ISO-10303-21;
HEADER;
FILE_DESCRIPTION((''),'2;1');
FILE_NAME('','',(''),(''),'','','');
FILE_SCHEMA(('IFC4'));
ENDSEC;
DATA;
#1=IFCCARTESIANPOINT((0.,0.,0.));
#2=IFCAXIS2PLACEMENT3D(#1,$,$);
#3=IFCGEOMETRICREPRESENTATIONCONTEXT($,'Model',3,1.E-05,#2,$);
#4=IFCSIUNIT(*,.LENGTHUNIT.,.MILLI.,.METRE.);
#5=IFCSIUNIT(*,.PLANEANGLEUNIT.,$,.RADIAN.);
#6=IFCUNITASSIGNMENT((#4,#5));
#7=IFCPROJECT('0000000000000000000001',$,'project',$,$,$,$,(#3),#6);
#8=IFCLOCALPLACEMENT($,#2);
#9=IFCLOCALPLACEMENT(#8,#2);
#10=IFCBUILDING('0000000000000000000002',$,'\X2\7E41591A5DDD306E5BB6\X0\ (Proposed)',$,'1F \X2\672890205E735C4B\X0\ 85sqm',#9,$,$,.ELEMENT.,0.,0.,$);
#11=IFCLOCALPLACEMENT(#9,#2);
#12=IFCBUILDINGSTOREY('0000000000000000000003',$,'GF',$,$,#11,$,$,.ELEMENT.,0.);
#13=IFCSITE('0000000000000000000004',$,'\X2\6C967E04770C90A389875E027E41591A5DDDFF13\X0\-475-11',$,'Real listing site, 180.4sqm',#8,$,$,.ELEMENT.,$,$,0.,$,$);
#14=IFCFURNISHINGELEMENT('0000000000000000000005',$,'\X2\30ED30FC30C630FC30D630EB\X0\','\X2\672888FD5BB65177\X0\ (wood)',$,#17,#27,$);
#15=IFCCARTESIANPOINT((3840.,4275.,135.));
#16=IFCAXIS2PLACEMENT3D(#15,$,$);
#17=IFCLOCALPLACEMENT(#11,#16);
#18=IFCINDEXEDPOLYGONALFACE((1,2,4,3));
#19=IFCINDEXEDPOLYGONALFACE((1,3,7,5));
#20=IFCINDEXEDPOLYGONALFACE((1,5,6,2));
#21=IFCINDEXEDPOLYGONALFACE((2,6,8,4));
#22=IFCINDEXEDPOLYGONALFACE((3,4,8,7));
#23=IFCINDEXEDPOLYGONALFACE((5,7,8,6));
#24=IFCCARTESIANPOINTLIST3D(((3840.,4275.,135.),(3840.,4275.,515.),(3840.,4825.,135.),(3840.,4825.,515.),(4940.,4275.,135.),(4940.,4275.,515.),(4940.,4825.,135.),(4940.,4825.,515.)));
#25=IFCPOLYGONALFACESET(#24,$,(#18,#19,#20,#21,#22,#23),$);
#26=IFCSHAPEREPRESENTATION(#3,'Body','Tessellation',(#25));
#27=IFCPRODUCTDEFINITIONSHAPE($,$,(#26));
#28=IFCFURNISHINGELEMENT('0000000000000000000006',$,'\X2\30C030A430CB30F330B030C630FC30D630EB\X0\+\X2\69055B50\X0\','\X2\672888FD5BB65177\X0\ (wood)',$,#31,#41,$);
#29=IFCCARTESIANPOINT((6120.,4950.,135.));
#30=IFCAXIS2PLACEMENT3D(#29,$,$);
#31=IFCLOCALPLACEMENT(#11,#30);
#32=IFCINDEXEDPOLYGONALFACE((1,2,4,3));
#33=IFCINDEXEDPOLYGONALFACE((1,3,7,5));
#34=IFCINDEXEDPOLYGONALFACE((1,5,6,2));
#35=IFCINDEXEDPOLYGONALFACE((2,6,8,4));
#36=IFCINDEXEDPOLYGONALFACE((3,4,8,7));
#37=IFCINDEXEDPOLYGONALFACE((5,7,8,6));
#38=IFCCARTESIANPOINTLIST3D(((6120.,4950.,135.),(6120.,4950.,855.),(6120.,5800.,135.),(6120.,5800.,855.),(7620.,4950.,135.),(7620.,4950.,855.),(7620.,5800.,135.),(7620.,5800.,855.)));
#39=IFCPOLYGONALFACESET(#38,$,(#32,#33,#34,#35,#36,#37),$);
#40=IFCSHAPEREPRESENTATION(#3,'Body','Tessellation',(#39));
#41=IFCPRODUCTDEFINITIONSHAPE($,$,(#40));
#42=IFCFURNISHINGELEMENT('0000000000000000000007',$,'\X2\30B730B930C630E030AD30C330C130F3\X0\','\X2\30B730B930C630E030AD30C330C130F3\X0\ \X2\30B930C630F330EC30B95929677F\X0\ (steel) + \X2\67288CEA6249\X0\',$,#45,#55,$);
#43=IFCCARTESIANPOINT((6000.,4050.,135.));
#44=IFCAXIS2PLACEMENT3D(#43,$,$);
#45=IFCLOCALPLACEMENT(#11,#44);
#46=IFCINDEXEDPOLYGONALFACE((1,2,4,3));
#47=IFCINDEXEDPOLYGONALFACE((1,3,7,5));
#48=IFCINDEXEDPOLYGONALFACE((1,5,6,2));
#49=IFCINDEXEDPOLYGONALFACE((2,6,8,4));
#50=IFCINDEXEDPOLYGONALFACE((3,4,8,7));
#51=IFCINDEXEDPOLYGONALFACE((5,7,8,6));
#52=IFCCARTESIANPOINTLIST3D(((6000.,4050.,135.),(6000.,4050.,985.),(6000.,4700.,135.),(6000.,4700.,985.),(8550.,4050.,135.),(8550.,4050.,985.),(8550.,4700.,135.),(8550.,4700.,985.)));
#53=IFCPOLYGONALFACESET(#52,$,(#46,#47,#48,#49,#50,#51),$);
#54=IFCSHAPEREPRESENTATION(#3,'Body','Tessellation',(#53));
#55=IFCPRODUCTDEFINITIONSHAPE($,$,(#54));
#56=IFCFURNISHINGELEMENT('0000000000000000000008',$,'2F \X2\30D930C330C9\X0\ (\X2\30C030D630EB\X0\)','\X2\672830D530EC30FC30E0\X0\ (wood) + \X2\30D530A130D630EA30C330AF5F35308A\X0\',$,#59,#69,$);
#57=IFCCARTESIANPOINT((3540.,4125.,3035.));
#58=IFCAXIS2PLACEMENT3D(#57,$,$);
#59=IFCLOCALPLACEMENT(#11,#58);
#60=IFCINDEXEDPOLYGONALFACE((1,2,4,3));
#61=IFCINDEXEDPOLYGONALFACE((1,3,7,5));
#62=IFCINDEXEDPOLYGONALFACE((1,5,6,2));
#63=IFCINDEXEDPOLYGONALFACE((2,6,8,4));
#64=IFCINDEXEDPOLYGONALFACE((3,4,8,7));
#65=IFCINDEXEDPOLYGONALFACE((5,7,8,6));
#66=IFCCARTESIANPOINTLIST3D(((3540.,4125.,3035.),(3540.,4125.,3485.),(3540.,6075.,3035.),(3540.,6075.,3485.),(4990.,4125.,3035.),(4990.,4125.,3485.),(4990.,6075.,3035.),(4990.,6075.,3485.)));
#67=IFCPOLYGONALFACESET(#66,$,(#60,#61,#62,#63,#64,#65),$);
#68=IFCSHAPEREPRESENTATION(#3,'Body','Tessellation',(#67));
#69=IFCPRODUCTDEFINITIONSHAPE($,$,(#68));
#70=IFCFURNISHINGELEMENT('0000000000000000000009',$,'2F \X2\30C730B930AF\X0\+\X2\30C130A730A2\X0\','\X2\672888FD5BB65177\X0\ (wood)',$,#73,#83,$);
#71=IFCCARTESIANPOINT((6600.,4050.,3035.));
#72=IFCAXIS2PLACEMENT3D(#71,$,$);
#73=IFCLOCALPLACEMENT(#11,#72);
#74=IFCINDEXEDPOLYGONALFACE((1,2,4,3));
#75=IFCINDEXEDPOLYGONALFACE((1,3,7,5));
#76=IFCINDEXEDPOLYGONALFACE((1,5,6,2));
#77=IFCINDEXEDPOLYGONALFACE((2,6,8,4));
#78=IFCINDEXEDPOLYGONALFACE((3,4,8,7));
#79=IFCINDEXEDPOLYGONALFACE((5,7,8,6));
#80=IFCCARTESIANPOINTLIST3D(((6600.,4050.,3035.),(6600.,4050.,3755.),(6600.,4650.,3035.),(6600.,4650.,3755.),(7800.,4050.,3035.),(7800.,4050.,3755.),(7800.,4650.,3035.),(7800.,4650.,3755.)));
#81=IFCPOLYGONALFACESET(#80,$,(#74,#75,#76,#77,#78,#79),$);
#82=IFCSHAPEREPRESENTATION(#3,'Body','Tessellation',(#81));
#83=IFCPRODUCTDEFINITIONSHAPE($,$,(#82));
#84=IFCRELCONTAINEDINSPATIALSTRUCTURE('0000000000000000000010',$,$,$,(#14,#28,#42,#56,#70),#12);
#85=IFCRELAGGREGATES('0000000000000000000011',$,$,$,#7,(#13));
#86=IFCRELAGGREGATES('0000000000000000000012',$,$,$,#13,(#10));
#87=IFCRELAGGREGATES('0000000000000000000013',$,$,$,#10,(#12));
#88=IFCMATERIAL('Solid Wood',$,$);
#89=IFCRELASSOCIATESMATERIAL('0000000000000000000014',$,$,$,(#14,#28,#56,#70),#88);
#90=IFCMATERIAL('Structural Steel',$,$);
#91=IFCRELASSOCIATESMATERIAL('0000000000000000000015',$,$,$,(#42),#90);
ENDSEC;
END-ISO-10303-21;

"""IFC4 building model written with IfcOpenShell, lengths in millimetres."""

from ifc_helpers import new_model, si_unit, frame, frame_2d, origin, place, context, project, spatial, rectangle, extrude, material, element, save


model = new_model("IFC4")

# Units and contexts
model_context = context("Model", 3, precision=1e-05, world=origin())
ifc_project = project(units=[si_unit("LENGTHUNIT", "METRE", prefix="MILLI"), si_unit("PLANEANGLEUNIT", "RADIAN")], contexts=[model_context])

# Site, building, storey
site_placement = place(None, origin())
site = spatial("IfcSite", under=ifc_project, at=site_placement, Name="沖縄県那覇市繁多川３-475-11", ObjectType="Real listing site, 180.4sqm", CompositionType="ELEMENT", RefElevation=0.0)
building_placement = place(site_placement, origin())
building = spatial("IfcBuilding", under=site, at=building_placement, Name="繁多川の家 (Proposed)", ObjectType="1F 木造平屋 85sqm", CompositionType="ELEMENT", ElevationOfRefHeight=0.0, ElevationOfTerrain=0.0)
storey_placement = place(building_placement, origin())
storey = spatial("IfcBuildingStorey", under=building, at=storey_placement, Name="GF", CompositionType="ELEMENT", Elevation=0.0)

# Shared definitions
ifc_material_1 = material(Name="Solid Wood")

# Shared definitions
ifc_material_2 = material(Name="Structural Steel")

# Furnishing elements
furnishing_1_placement = place(storey_placement, frame((3840.0, 4275.0, 135.0)))
element("IfcFurnishingElement", 1, at=furnishing_1_placement, inside=storey, material=ifc_material_1, Name="ローテーブル", Description="木製家具 (wood)", context=model_context, shape_type="SweptSolid", body=[
    extrude(rectangle(XDim=1100.0, YDim=550.0, at=frame_2d((550.0, 275.0))), frame((3840.0, 4275.0, 135.0)), (0.0, 0.0, 1.0), 380.0),
])
furnishing_2_placement = place(storey_placement, frame((6120.0, 4950.0, 135.0)))
element("IfcFurnishingElement", 2, at=furnishing_2_placement, inside=storey, material=ifc_material_1, Name="ダイニングテーブル+椅子", Description="木製家具 (wood)", context=model_context, shape_type="SweptSolid", body=[
    extrude(rectangle(XDim=1500.0, YDim=850.0, at=frame_2d((750.0, 425.0))), frame((6120.0, 4950.0, 135.0)), (0.0, 0.0, 1.0), 720.0),
])
furnishing_3_placement = place(storey_placement, frame((6000.0, 4050.0, 135.0)))
element("IfcFurnishingElement", 3, at=furnishing_3_placement, inside=storey, material=ifc_material_2, Name="システムキッチン", Description="システムキッチン ステンレス天板 (steel) + 木質扉", context=model_context, shape_type="SweptSolid", body=[
    extrude(rectangle(XDim=2550.0, YDim=650.0, at=frame_2d((1275.0, 325.0))), frame((6000.0, 4050.0, 135.0)), (0.0, 0.0, 1.0), 850.0),
])
furnishing_4_placement = place(storey_placement, frame((3540.0, 4125.0, 3035.0)))
element("IfcFurnishingElement", 4, at=furnishing_4_placement, inside=storey, material=ifc_material_1, Name="2F ベッド (ダブル)", Description="木フレーム (wood) + ファブリック張り", context=model_context, shape_type="SweptSolid", body=[
    extrude(rectangle(XDim=1450.0, YDim=1950.0, at=frame_2d((725.0, 975.0))), frame((3540.0, 4125.0, 3035.0)), (0.0, 0.0, 1.0), 450.0),
])
furnishing_5_placement = place(storey_placement, frame((6600.0, 4050.0, 3035.0)))
element("IfcFurnishingElement", 5, at=furnishing_5_placement, inside=storey, material=ifc_material_1, Name="2F デスク+チェア", Description="木製家具 (wood)", context=model_context, shape_type="SweptSolid", body=[
    extrude(rectangle(XDim=1200.0, YDim=600.0, at=frame_2d((600.0, 300.0))), frame((6600.0, 4050.0, 3035.0)), (0.0, 0.0, 1.0), 720.0),
])

save(model, "model.ifc")
